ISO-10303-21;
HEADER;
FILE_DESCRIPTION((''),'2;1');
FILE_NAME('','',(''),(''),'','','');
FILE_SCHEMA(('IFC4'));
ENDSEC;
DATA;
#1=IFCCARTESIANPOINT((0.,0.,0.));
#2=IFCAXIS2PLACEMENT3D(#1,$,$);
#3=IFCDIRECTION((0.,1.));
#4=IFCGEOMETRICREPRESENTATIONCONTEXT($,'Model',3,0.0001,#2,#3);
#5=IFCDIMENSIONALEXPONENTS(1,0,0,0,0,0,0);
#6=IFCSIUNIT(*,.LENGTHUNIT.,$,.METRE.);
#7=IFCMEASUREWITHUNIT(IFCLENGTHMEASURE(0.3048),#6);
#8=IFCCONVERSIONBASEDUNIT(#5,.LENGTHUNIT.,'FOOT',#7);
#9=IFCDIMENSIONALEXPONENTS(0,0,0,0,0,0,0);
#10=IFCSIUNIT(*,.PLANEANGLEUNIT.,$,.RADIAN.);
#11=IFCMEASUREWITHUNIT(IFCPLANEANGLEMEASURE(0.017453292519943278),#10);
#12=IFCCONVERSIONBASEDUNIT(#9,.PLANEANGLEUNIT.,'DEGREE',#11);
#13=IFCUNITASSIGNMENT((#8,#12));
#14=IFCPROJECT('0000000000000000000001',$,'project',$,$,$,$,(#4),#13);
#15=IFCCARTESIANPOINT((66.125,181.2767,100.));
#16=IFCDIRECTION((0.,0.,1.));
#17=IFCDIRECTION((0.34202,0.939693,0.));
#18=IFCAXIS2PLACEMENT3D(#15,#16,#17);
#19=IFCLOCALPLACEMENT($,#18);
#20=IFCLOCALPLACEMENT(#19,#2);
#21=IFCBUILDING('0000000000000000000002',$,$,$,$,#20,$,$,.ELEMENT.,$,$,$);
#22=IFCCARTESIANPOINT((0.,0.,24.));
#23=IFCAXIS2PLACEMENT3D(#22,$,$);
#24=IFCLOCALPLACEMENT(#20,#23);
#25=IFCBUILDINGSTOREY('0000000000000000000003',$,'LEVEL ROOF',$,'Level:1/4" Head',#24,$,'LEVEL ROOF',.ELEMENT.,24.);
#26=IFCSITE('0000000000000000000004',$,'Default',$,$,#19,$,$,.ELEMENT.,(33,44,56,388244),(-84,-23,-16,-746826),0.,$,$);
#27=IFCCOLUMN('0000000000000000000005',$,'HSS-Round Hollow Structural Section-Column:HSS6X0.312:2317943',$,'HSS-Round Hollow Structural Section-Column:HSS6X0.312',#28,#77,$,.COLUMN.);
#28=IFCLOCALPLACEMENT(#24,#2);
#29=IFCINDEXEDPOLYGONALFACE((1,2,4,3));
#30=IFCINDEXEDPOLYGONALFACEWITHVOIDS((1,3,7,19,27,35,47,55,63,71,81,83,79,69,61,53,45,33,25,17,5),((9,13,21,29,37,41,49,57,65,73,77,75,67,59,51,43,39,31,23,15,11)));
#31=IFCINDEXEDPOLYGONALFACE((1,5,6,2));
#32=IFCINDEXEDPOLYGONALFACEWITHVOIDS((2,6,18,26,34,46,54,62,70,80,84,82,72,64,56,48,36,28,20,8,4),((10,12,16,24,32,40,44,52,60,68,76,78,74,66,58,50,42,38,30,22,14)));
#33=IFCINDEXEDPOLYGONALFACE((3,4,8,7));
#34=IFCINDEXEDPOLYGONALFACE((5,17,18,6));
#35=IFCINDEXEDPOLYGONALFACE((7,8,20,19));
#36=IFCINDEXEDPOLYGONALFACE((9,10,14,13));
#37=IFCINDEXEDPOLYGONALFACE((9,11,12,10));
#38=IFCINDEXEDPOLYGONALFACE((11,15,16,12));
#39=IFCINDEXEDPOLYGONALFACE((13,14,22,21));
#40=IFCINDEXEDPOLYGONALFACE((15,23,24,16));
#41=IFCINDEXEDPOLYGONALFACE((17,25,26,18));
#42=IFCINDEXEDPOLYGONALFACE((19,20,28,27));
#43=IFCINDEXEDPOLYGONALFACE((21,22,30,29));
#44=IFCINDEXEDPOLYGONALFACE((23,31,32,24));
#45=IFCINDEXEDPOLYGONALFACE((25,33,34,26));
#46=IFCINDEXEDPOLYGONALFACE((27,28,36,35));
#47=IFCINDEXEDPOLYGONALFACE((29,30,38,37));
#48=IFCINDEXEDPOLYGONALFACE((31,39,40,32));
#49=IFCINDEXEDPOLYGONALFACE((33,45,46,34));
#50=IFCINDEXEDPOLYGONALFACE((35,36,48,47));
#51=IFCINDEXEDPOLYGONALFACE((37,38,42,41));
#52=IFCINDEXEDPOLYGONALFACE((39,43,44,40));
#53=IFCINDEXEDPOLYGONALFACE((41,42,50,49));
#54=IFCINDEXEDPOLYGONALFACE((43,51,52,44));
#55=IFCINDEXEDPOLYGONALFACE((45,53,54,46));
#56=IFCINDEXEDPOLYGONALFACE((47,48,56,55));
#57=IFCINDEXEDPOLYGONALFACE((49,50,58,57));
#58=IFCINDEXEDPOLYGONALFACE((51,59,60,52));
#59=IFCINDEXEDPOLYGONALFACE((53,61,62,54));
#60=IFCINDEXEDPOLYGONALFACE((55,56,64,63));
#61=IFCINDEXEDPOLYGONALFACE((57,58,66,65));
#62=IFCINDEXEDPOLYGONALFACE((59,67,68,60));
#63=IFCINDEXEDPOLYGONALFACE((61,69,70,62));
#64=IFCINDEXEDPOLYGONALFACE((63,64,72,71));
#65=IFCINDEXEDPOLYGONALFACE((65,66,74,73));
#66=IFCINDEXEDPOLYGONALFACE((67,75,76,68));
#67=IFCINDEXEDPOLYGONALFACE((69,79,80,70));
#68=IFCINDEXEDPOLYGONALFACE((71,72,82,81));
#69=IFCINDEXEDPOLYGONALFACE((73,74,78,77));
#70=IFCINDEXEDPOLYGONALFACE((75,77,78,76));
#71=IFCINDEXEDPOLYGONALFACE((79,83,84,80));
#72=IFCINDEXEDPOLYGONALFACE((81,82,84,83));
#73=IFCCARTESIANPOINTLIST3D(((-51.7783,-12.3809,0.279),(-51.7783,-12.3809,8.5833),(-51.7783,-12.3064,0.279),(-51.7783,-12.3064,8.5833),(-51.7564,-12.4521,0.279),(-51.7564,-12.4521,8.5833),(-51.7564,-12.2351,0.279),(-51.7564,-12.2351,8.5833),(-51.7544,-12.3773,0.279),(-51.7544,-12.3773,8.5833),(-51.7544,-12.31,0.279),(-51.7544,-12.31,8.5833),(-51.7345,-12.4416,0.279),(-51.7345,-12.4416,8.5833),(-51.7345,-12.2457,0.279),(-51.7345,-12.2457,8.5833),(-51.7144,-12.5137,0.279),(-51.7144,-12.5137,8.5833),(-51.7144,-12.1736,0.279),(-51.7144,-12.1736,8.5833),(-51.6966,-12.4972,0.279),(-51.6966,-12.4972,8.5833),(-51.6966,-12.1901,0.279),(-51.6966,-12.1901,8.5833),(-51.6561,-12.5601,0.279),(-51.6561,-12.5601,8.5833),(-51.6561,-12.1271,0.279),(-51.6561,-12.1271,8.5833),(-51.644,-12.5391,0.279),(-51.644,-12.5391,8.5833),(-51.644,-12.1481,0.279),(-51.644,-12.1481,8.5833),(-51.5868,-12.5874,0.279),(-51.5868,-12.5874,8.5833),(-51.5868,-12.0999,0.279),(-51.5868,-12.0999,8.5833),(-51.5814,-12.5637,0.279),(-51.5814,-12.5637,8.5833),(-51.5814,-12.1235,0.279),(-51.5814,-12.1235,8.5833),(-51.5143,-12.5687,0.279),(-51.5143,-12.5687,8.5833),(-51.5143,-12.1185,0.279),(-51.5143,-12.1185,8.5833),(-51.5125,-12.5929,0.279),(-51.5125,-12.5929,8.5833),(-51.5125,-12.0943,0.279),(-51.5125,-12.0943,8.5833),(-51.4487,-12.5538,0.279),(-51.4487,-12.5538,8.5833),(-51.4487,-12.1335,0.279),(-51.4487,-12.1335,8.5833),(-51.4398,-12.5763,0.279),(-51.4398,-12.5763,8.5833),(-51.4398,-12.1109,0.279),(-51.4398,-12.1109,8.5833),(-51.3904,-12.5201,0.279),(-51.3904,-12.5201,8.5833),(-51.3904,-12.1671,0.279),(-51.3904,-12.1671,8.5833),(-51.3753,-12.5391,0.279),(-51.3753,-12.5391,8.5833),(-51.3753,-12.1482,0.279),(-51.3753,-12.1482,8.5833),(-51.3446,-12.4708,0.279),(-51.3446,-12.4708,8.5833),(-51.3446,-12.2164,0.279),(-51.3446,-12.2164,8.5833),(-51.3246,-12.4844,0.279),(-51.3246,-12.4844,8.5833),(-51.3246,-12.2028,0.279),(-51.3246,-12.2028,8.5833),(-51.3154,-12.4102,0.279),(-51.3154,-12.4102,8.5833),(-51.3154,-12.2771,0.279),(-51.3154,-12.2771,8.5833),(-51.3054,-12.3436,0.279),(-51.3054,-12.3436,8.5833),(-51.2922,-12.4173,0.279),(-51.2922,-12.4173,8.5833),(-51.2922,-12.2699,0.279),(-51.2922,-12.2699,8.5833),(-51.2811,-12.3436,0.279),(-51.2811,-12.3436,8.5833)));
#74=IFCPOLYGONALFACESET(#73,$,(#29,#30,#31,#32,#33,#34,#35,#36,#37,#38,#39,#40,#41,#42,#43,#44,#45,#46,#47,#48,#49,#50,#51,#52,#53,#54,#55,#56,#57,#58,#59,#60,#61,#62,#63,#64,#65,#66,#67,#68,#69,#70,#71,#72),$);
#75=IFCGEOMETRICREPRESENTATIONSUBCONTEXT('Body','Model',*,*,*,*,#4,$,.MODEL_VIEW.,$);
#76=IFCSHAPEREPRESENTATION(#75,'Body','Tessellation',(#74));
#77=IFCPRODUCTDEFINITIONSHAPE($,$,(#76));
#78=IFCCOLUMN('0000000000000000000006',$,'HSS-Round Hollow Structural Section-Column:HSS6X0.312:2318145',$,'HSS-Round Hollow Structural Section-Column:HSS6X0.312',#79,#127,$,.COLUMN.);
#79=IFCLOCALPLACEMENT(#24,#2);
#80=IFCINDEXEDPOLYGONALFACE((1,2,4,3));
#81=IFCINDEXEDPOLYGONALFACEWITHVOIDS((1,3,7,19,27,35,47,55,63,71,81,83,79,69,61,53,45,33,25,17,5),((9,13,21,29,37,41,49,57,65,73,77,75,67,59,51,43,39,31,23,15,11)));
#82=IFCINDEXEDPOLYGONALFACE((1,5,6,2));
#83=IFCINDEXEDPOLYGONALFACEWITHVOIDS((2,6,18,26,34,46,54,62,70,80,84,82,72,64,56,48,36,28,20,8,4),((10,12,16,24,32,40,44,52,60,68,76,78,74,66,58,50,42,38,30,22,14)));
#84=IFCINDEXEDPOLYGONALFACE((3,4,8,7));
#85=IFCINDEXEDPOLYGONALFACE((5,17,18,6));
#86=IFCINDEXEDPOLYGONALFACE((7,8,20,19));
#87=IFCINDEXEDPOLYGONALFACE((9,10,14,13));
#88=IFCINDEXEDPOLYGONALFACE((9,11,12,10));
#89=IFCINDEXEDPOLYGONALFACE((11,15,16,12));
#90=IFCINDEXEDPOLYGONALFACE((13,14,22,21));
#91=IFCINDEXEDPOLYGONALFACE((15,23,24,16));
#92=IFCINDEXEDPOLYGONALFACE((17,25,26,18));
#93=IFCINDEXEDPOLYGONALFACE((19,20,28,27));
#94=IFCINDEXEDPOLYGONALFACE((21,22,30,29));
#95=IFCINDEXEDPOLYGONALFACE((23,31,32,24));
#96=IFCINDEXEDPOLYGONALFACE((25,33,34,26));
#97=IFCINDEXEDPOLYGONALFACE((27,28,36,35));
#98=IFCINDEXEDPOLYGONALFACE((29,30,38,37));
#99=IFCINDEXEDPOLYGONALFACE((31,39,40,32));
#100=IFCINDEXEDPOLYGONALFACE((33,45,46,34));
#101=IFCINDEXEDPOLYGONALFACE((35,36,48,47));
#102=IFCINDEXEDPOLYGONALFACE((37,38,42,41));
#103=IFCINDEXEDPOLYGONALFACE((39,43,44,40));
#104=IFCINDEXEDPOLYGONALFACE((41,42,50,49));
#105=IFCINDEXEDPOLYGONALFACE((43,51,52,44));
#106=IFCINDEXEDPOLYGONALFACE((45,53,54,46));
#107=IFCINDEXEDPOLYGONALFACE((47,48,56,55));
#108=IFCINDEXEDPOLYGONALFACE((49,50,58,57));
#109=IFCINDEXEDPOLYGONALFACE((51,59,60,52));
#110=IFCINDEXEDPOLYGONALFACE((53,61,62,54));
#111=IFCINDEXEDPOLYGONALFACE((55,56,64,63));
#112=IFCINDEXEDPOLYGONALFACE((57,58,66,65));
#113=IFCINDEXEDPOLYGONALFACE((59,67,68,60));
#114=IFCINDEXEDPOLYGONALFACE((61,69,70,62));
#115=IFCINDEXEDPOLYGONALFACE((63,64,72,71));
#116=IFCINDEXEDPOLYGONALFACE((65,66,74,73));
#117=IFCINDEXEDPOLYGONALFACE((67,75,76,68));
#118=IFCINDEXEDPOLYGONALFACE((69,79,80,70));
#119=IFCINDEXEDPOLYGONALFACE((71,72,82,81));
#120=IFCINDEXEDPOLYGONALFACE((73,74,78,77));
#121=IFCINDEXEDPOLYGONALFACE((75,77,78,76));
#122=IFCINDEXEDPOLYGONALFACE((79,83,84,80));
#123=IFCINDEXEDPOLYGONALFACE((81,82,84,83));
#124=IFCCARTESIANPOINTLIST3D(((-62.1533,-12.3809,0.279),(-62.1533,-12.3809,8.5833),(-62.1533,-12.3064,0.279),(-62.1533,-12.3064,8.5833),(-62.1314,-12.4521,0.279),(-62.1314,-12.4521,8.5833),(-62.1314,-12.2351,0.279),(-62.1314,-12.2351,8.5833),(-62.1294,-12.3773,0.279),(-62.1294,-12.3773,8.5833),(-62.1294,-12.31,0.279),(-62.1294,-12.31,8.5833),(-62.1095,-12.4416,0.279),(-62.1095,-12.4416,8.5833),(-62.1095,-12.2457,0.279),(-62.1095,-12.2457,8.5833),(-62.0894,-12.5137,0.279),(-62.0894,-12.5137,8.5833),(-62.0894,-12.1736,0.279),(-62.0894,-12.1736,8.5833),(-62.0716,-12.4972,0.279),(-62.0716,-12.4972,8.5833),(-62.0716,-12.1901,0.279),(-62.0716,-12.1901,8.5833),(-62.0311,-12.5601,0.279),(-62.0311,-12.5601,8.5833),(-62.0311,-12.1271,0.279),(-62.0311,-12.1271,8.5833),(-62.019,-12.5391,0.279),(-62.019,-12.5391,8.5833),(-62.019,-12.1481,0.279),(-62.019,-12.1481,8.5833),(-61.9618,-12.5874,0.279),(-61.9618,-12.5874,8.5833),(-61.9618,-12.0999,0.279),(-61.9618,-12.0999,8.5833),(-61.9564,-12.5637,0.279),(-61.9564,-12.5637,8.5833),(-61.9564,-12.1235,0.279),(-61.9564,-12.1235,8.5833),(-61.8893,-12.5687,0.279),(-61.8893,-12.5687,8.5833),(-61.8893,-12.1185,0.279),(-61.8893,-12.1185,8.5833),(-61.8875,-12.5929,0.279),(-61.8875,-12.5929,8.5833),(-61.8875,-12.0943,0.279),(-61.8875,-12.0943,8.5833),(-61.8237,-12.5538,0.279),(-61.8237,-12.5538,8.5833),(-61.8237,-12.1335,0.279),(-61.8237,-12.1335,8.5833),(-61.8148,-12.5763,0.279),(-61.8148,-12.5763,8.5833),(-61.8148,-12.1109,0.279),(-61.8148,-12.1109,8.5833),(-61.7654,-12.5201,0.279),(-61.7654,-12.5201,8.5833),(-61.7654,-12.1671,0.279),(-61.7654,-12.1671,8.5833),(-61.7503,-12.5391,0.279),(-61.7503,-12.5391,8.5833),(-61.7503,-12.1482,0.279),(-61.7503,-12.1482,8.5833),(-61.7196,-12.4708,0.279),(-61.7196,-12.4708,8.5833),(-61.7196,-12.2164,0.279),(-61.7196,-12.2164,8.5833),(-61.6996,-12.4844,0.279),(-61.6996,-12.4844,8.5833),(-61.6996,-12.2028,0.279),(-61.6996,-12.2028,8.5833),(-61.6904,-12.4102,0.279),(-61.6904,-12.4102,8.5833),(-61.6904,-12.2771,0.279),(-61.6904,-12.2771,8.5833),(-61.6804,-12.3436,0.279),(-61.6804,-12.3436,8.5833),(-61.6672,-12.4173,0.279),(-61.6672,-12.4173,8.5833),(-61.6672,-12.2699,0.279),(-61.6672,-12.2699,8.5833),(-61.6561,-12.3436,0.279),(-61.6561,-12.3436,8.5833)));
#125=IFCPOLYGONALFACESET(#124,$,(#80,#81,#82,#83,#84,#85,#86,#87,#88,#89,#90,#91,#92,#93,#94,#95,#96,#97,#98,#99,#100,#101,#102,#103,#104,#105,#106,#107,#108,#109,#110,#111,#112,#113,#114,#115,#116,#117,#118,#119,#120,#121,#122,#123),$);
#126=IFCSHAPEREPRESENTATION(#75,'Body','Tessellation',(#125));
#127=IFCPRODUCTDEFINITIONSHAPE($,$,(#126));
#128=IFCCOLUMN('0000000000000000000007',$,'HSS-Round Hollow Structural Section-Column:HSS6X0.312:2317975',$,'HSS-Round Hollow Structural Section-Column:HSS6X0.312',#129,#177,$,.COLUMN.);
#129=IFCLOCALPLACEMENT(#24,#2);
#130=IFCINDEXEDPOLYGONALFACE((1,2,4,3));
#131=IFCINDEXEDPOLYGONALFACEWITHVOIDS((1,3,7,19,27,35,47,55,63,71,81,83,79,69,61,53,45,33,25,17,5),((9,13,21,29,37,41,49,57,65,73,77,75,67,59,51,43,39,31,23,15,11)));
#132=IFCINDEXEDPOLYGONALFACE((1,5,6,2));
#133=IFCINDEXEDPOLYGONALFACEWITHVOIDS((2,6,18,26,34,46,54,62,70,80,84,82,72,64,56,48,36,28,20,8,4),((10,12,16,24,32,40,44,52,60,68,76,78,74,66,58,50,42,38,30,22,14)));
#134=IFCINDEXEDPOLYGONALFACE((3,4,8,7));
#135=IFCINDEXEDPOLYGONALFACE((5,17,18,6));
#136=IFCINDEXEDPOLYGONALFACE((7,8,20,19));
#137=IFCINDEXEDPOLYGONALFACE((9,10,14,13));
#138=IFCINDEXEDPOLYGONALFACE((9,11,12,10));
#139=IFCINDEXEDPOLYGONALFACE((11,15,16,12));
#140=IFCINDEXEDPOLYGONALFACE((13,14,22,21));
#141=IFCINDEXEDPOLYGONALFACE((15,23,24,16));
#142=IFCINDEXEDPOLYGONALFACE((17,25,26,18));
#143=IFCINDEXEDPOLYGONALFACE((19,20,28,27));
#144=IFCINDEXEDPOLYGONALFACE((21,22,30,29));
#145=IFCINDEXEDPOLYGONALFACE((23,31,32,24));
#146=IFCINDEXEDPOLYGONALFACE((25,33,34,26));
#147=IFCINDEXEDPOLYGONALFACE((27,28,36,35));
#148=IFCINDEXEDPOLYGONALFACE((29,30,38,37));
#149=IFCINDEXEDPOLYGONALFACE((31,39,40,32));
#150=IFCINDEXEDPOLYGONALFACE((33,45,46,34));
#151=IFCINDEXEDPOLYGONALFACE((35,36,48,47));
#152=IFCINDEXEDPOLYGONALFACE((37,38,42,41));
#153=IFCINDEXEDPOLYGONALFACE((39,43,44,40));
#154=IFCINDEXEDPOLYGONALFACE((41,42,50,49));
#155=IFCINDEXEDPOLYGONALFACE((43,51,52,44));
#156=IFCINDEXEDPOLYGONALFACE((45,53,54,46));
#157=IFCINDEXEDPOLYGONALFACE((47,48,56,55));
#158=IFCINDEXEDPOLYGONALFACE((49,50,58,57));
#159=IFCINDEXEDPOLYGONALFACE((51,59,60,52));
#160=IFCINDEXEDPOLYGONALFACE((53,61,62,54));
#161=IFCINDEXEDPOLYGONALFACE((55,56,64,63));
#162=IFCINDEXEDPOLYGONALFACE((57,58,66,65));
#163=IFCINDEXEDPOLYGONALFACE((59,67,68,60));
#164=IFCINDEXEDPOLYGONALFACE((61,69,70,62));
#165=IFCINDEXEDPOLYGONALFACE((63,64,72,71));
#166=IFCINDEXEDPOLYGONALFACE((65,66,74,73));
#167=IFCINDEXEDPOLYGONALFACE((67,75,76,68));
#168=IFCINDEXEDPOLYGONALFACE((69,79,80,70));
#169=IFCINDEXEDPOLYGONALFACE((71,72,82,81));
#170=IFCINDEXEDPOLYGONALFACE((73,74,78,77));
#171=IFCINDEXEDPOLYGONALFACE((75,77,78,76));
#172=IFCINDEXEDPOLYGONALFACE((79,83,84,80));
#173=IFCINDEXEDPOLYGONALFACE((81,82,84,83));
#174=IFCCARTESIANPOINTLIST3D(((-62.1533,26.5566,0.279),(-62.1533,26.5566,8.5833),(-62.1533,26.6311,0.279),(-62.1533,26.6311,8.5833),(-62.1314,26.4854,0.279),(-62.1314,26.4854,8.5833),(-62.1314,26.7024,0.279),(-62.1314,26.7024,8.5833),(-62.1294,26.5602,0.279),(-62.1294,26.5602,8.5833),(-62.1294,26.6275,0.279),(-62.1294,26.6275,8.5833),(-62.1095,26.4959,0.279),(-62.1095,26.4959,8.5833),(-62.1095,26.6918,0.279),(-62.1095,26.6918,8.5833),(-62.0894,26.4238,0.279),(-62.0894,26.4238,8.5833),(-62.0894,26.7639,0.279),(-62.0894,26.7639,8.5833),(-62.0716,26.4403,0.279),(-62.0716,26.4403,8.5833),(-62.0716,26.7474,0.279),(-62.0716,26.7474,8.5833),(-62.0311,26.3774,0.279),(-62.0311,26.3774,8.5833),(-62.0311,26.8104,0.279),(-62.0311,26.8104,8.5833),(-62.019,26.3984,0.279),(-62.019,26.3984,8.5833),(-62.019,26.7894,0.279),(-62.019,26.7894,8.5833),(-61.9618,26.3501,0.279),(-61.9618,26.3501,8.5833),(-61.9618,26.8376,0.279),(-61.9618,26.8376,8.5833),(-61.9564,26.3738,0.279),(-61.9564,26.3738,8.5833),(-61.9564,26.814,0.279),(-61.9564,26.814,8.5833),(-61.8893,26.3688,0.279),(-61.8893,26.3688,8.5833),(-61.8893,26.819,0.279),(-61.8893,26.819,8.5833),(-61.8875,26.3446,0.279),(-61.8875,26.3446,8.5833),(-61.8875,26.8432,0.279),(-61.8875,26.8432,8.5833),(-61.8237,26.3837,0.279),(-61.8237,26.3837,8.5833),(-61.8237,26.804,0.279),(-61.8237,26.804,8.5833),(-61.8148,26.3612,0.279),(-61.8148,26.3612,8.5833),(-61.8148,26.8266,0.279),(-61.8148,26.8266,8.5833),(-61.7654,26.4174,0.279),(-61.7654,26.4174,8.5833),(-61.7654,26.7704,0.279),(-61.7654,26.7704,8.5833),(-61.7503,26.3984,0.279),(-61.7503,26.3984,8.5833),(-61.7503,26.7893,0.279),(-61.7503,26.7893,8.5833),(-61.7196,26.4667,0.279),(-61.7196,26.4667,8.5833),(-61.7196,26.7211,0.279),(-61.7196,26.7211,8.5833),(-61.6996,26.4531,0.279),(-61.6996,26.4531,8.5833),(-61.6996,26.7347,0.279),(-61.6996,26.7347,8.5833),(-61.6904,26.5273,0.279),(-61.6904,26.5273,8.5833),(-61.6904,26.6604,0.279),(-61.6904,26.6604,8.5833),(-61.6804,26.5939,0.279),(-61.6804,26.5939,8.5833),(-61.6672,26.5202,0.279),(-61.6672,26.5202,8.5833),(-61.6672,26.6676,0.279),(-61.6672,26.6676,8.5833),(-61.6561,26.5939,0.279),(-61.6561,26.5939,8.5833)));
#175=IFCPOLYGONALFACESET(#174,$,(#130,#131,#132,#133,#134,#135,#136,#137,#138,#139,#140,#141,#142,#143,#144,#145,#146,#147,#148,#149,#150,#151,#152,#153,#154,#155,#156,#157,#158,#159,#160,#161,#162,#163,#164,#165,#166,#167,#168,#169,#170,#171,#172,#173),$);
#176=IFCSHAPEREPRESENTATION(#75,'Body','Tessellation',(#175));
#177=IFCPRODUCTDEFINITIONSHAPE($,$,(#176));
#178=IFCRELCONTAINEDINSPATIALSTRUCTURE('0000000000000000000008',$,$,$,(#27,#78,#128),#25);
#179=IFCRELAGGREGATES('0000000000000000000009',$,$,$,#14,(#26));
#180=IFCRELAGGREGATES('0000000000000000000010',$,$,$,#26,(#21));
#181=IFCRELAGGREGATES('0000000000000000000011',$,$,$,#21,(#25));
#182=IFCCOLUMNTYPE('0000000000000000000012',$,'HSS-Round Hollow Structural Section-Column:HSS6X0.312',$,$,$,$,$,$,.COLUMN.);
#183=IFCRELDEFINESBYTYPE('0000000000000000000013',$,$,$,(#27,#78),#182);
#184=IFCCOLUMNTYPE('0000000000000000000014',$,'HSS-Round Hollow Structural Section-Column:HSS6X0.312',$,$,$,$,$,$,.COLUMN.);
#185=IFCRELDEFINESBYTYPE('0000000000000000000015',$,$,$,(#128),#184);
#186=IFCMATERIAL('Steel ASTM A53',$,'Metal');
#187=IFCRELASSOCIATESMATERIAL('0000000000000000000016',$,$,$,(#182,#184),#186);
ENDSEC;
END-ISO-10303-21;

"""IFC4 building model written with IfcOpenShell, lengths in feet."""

from ifc_helpers import new_model, entity, si_unit, converted_unit, direction, frame, frame_2d, origin, place, context, subcontext, project, spatial, hollow_circle, extrude, source, transform, mapped, material, material_profile, profile_set, type_object, type_shapes, element, save


model = new_model("IFC4")

# Units and contexts
model_context = context("Model", 3, precision=0.0001, world=origin(), true_north=direction((0.0, 1.0)))
body_context = subcontext(model_context, "Body", "Model", "MODEL_VIEW")
ifc_project = project(units=[converted_unit("LENGTHUNIT", "FOOT", entity("IfcLengthMeasure", 0.3048), si_unit("LENGTHUNIT", "METRE"), dimensions=[1, 0, 0, 0, 0, 0, 0]), converted_unit("PLANEANGLEUNIT", "DEGREE", entity("IfcPlaneAngleMeasure", 0.017453292519943278), si_unit("PLANEANGLEUNIT", "RADIAN"), dimensions=[0, 0, 0, 0, 0, 0, 0])], contexts=[model_context])

# Site, building, storey
site_placement = place(None, frame((66.125, 181.2767, 100.0), z_axis=(0.0, 0.0, 1.0), x_axis=(0.34202, 0.939693, 0.0)))
site = spatial("IfcSite", under=ifc_project, at=site_placement, Name="Default", CompositionType="ELEMENT", RefLatitude=(33, 44, 56, 388244), RefLongitude=(-84, -23, -16, -746826), RefElevation=0.0)
building_placement = place(site_placement, origin())
building = spatial("IfcBuilding", under=site, at=building_placement, CompositionType="ELEMENT")
storey_placement = place(building_placement, frame((0.0, 0.0, 24.0)))
storey = spatial("IfcBuildingStorey", under=building, at=storey_placement, Name="LEVEL ROOF", ObjectType="Level:1/4\" Head", LongName="LEVEL ROOF", CompositionType="ELEMENT", Elevation=24.0)

# Columns
ifc_material_1 = material(Name="Steel ASTM A53", Category="Metal")
ifc_material_profile_1 = material_profile(ifc_material_1, hollow_circle(Radius=0.25, WallThickness=0.0242, at=frame_2d((0.0, 0.0), x_axis=(1.0, 0.0))), Name="HSS6X0.312")
ifc_profile_set_1 = profile_set([ifc_material_profile_1], Name="HSS6X0.312")
column_type_1 = type_object("IfcColumnType", Name="HSS-Round Hollow Structural Section-Column:HSS6X0.312", PredefinedType="COLUMN", material=ifc_profile_set_1)
shared_shape_1 = source(origin(), body_context, "Body", "SweptSolid", [
    extrude(hollow_circle(Radius=0.25, WallThickness=0.0242, at=frame_2d((0.0, 0.0), x_axis=(1.0, 0.0))), frame((0.0, 0.0, 24.279)), (0.0, 0.0, 1.0), 8.3044),
])
type_shapes(column_type_1, [shared_shape_1])
for number, where, name in (
    (1, (-51.5311, -12.3436, -24.0), "HSS-Round Hollow Structural Section-Column:HSS6X0.312:2317943"),
    (2, (-61.9061, -12.3436, -24.0), "HSS-Round Hollow Structural Section-Column:HSS6X0.312:2318145"),
):
    element("IfcColumn", number, at=place(storey_placement, frame(where)), inside=storey, type_object=column_type_1, Name=name, ObjectType="HSS-Round Hollow Structural Section-Column:HSS6X0.312", PredefinedType="COLUMN", context=body_context, shape_type="MappedRepresentation", body=[
        mapped(shared_shape_1, transform((0.0, 0.0, 0.0), scale=1.0)),
    ])
column_type_2 = type_object("IfcColumnType", Name="HSS-Round Hollow Structural Section-Column:HSS6X0.312", PredefinedType="COLUMN", material=ifc_profile_set_1)
shared_shape_2 = source(origin(), body_context, "Body", "SweptSolid", [
    extrude(hollow_circle(Radius=0.25, WallThickness=0.0242, at=frame_2d((0.0, 0.0), x_axis=(1.0, 0.0))), frame((0.0, 0.0, 24.279)), (0.0, 0.0, 1.0), 8.3044),
])
type_shapes(column_type_2, [shared_shape_2])
for number, where, name in (
    (3, (-61.9061, 26.5939, -24.0), "HSS-Round Hollow Structural Section-Column:HSS6X0.312:2317975"),
):
    element("IfcColumn", number, at=place(storey_placement, frame(where)), inside=storey, type_object=column_type_2, Name=name, ObjectType="HSS-Round Hollow Structural Section-Column:HSS6X0.312", PredefinedType="COLUMN", context=body_context, shape_type="MappedRepresentation", body=[
        mapped(shared_shape_2, transform((0.0, 0.0, 0.0), scale=1.0)),
    ])

save(model, "model.ifc")
